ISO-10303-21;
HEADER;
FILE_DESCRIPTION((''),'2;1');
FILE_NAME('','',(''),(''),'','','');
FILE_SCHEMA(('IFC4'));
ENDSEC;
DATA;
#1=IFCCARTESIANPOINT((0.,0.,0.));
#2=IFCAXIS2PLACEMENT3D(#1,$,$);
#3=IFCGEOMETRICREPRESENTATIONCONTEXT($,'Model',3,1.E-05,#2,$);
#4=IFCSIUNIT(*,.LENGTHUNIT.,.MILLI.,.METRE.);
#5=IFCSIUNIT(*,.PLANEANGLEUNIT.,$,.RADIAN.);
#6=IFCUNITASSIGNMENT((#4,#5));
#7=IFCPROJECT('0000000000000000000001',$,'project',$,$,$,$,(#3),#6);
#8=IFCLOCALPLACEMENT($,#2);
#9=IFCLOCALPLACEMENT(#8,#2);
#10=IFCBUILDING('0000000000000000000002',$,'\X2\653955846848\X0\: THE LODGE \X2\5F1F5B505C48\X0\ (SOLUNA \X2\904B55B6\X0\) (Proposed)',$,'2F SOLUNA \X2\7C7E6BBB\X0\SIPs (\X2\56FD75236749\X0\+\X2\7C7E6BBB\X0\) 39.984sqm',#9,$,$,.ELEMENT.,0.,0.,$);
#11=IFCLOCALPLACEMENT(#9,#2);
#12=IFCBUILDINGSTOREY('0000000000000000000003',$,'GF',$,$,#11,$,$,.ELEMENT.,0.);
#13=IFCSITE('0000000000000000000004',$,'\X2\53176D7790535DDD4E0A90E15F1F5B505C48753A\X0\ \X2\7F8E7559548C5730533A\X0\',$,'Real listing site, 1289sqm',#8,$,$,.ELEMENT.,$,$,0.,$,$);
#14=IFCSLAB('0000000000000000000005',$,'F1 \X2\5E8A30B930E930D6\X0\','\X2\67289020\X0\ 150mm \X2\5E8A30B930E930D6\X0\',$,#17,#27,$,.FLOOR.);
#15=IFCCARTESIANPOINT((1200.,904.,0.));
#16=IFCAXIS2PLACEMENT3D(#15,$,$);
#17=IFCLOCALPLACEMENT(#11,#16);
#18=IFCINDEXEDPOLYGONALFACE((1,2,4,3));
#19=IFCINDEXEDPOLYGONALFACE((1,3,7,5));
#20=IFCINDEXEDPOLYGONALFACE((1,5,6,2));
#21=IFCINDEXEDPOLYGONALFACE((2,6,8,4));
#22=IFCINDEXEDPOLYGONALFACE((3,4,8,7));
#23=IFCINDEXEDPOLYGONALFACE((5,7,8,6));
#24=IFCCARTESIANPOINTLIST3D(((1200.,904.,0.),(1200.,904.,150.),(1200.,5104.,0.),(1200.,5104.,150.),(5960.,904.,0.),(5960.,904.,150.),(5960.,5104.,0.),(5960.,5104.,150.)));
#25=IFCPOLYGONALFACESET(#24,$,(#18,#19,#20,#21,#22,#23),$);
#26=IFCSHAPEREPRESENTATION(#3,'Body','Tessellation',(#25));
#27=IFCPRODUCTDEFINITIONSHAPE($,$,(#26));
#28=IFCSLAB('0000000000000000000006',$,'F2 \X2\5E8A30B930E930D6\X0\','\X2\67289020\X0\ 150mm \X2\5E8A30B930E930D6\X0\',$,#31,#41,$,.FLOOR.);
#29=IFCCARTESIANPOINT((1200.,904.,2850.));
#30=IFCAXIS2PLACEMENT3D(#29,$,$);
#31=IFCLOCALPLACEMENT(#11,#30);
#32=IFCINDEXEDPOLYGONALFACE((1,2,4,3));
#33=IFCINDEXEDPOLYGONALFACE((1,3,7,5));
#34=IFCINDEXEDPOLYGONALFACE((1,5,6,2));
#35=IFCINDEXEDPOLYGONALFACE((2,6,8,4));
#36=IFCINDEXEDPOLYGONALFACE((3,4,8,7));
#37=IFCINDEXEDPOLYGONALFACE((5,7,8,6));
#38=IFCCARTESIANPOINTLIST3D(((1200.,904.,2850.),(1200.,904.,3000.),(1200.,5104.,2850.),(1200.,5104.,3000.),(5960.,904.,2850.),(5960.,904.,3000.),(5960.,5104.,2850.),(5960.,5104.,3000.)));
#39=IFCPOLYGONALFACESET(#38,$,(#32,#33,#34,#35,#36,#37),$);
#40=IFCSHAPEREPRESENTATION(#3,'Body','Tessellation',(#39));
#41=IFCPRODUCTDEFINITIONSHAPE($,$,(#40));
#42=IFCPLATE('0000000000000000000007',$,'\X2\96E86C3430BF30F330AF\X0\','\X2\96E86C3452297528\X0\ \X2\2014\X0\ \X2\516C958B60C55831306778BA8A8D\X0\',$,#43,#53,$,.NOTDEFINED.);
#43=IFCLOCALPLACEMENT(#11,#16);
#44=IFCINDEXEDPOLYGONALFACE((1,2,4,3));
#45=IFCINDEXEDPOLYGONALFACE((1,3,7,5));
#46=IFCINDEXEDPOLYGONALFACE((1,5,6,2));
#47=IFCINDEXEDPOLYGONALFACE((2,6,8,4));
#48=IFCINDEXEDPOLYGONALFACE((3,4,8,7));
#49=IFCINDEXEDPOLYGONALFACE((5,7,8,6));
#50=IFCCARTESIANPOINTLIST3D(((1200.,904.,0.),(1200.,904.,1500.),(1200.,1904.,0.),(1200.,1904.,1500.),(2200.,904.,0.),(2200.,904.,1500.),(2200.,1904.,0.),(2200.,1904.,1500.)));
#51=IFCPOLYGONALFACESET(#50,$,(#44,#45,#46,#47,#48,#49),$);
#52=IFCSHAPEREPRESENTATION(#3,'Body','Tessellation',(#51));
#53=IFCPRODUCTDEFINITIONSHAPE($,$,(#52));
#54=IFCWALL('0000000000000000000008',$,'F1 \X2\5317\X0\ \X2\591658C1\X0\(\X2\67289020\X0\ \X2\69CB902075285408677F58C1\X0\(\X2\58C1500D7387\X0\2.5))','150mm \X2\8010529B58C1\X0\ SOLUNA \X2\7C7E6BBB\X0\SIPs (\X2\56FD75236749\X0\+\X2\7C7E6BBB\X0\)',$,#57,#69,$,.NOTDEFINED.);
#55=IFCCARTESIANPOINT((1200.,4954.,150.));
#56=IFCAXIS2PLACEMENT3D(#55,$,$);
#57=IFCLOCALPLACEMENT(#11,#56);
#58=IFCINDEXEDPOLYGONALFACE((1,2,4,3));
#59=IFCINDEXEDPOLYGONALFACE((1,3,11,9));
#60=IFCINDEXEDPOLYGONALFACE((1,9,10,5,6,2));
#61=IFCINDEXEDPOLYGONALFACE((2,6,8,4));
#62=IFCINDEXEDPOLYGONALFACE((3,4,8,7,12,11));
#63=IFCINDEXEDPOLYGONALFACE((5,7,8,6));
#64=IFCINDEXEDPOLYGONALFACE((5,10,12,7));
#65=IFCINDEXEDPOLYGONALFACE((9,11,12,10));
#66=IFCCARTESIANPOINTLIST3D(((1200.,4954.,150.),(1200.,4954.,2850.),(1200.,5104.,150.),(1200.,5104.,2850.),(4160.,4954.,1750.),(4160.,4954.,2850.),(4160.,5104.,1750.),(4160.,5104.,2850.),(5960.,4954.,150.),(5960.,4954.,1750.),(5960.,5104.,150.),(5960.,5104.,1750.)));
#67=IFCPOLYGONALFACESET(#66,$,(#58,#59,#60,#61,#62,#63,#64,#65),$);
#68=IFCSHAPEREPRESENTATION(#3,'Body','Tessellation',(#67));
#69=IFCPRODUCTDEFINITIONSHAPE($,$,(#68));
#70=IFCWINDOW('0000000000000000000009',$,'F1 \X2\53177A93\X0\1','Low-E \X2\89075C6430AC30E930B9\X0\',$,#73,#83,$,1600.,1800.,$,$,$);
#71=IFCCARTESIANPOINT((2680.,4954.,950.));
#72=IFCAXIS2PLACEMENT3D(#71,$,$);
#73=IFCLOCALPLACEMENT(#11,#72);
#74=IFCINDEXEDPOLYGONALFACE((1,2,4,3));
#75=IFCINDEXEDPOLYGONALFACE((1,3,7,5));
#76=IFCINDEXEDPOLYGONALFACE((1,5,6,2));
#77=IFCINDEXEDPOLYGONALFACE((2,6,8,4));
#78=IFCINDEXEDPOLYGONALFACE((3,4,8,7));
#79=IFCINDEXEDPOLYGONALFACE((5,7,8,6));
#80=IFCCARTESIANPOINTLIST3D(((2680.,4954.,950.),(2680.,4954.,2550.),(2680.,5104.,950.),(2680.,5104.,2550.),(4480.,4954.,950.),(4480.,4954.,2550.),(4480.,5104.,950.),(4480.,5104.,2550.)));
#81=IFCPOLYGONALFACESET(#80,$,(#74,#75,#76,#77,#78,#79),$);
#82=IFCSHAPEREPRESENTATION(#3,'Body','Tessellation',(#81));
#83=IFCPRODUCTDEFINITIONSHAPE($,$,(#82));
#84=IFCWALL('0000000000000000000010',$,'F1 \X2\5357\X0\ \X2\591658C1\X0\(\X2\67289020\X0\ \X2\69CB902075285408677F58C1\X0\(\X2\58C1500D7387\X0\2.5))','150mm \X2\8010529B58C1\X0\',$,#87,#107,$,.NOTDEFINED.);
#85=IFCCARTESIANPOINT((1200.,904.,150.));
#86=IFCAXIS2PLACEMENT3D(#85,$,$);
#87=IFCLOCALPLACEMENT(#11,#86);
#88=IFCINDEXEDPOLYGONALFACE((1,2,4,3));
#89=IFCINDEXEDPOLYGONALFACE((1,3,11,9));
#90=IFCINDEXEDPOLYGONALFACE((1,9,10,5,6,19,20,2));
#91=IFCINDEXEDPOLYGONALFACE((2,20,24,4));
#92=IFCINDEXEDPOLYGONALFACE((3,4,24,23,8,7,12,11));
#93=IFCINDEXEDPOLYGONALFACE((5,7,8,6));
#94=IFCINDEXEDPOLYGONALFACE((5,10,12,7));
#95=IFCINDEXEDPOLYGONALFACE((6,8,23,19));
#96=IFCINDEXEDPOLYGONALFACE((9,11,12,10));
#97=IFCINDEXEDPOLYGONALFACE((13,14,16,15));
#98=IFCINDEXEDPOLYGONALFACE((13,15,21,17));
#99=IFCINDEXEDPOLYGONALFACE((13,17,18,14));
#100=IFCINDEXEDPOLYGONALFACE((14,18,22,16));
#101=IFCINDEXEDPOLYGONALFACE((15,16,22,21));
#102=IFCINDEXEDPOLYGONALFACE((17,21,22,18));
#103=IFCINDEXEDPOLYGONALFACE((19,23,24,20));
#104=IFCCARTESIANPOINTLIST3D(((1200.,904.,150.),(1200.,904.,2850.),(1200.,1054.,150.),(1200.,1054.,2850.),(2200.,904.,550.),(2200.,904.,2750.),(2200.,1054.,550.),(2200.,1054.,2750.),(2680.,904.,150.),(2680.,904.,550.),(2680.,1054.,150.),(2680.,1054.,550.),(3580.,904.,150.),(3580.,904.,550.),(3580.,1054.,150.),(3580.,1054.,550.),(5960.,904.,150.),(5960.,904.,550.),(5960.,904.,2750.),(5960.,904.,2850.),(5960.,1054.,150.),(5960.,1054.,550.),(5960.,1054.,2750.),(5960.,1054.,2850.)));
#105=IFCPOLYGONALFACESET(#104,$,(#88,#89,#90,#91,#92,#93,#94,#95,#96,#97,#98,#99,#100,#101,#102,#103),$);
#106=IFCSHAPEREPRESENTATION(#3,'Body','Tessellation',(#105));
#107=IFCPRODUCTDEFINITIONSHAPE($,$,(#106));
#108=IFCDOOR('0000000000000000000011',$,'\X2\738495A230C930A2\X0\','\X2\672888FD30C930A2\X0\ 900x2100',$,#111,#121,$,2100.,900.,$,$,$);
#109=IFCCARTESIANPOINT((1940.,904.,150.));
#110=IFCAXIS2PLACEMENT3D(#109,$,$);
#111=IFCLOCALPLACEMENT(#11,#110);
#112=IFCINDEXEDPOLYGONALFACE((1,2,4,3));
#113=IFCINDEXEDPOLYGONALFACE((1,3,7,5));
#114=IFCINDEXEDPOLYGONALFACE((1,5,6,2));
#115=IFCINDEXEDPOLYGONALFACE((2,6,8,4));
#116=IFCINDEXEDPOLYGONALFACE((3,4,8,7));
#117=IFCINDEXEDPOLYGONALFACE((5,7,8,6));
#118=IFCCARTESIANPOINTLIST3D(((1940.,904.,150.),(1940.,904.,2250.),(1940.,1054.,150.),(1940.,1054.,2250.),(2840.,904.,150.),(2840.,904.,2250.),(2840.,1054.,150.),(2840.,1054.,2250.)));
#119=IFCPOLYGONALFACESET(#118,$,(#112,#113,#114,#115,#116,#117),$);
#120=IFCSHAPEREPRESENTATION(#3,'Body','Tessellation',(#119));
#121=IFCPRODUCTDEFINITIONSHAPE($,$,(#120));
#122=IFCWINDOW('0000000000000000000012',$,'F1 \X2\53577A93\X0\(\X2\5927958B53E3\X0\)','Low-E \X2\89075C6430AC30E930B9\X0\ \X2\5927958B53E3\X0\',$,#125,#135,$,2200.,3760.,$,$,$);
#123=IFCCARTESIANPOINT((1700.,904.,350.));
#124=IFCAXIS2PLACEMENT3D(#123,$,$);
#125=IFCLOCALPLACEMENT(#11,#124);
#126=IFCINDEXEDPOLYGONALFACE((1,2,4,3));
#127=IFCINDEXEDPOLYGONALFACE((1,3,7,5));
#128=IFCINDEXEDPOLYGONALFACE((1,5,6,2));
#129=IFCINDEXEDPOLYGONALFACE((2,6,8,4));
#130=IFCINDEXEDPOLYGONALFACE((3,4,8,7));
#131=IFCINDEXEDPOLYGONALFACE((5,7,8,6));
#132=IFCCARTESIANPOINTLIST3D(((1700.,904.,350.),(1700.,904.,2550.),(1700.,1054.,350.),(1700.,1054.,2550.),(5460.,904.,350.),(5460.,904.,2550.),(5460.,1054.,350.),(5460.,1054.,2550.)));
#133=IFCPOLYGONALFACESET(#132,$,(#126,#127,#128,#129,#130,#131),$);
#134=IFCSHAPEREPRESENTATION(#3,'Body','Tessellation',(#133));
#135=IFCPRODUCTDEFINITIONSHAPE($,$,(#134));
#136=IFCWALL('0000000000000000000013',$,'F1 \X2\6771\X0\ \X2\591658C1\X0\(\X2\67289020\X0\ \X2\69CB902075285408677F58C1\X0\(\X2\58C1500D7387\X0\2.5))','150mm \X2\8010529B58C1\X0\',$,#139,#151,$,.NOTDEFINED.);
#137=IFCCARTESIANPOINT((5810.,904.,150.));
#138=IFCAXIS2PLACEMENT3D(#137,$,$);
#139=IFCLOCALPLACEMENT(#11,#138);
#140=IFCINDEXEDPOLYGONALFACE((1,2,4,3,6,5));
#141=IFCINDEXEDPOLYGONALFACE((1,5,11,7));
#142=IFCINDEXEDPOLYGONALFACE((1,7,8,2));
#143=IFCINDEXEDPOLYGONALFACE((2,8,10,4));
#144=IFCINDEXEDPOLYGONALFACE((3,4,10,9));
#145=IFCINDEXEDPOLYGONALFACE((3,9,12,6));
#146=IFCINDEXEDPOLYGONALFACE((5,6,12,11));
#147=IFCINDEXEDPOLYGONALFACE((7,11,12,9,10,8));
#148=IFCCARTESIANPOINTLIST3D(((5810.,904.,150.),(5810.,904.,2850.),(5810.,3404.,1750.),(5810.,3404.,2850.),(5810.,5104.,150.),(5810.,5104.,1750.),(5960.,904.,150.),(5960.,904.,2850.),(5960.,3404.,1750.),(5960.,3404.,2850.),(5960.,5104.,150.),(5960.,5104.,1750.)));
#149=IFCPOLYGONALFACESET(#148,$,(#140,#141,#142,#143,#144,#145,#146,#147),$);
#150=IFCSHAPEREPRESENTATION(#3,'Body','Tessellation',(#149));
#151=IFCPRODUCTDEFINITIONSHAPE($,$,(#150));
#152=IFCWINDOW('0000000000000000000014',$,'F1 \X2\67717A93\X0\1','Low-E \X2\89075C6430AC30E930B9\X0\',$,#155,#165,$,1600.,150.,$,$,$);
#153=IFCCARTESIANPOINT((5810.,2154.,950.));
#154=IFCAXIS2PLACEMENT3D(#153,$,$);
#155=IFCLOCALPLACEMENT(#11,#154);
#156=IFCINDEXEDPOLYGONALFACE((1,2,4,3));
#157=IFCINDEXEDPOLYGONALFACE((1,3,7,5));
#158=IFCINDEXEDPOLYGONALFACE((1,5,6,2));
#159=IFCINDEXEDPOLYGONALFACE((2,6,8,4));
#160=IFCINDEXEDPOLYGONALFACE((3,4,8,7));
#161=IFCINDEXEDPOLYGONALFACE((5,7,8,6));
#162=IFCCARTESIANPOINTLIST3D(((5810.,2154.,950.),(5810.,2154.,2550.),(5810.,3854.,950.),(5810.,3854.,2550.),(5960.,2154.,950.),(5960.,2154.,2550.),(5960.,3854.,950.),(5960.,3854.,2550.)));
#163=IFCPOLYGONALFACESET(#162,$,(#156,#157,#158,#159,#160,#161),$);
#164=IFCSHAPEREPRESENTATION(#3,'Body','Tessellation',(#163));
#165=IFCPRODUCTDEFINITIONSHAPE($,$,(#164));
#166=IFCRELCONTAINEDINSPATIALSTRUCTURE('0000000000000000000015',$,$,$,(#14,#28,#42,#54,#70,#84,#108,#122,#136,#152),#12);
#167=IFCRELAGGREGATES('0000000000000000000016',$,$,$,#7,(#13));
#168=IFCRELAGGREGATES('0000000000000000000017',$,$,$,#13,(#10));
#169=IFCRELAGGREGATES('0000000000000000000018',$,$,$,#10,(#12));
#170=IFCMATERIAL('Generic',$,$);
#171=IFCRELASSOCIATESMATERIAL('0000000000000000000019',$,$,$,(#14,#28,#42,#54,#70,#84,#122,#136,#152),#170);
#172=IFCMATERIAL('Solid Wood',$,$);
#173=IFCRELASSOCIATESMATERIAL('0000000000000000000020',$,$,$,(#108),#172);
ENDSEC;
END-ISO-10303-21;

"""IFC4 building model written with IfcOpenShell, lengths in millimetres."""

from ifc_helpers import new_model, si_unit, frame, frame_2d, origin, place, context, project, spatial, rectangle, extrude, material, element, fill, save


model = new_model("IFC4")

# Units and contexts
model_context = context("Model", 3, precision=1e-05, world=origin())
ifc_project = project(units=[si_unit("LENGTHUNIT", "METRE", prefix="MILLI"), si_unit("PLANEANGLEUNIT", "RADIAN")], contexts=[model_context])

# Site, building, storey
site_placement = place(None, origin())
site = spatial("IfcSite", under=ifc_project, at=site_placement, Name="北海道川上郡弟子屈町 美留和地区", ObjectType="Real listing site, 1289sqm", CompositionType="ELEMENT", RefElevation=0.0)
building_placement = place(site_placement, origin())
building = spatial("IfcBuilding", under=site, at=building_placement, Name="改善案: THE LODGE 弟子屈 (SOLUNA 運営) (Proposed)", ObjectType="2F SOLUNA 籾殻SIPs (国産杉+籾殻) 39.984sqm", CompositionType="ELEMENT", ElevationOfRefHeight=0.0, ElevationOfTerrain=0.0)
storey_placement = place(building_placement, origin())
storey = spatial("IfcBuildingStorey", under=building, at=storey_placement, Name="GF", CompositionType="ELEMENT", Elevation=0.0)

# Slabs
ifc_material_1 = material(Name="Generic")
slab_1_placement = place(storey_placement, frame((1200.0, 904.0, 0.0)))
element("IfcSlab", 1, at=slab_1_placement, inside=storey, material=ifc_material_1, Name="F1 床スラブ", Description="木造 150mm 床スラブ", PredefinedType="FLOOR", context=model_context, shape_type="SweptSolid", body=[
    extrude(rectangle(XDim=4760.0, YDim=4200.0, at=frame_2d((2380.0, 2100.0))), frame((1200.0, 904.0, 0.0)), (0.0, 0.0, 1.0), 150.0),
])
slab_2_placement = place(storey_placement, frame((1200.0, 904.0, 2850.0)))
element("IfcSlab", 2, at=slab_2_placement, inside=storey, material=ifc_material_1, Name="F2 床スラブ", Description="木造 150mm 床スラブ", PredefinedType="FLOOR", context=model_context, shape_type="SweptSolid", body=[
    extrude(rectangle(XDim=4760.0, YDim=4200.0, at=frame_2d((2380.0, 2100.0))), frame((1200.0, 904.0, 2850.0)), (0.0, 0.0, 1.0), 150.0),
])

# Plate
plate_placement = place(storey_placement, frame((1200.0, 904.0, 0.0)))
element("IfcPlate", 3, at=plate_placement, inside=storey, material=ifc_material_1, Name="雨水タンク", Description="雨水利用 — 公開情報で確認", PredefinedType="NOTDEFINED", context=model_context, shape_type="SweptSolid", body=[
    extrude(rectangle(XDim=1000.0, YDim=1000.0, at=frame_2d((500.0, 500.0))), frame((1200.0, 904.0, 0.0)), (0.0, 0.0, 1.0), 1500.0),
])

# Wall, opening, window
wall_1_placement = place(storey_placement, frame((1200.0, 4954.0, 150.0)))
wall_1 = element("IfcWall", 4, at=wall_1_placement, inside=storey, material=ifc_material_1, Name="F1 北 外壁(木造 構造用合板壁(壁倍率2.5))", Description="150mm 耐力壁 SOLUNA 籾殻SIPs (国産杉+籾殻)", PredefinedType="NOTDEFINED", context=model_context, shape_type="SweptSolid", body=[
    extrude(rectangle(XDim=4760.0, YDim=150.0, at=frame_2d((2380.0, 75.0))), frame((1200.0, 4954.0, 150.0)), (0.0, 0.0, 1.0), 2700.0),
])
opening_1_placement = place(storey_placement, frame((2680.0, 4954.0, 950.0)))
opening_1 = element("IfcOpeningElement", 5, at=opening_1_placement, cuts=wall_1, PredefinedType="NOTDEFINED", context=model_context, shape_type="SweptSolid", body=[
    extrude(rectangle(XDim=1800.0, YDim=150.0, at=frame_2d((900.0, 75.0))), frame((2680.0, 4954.0, 950.0)), (0.0, 0.0, 1.0), 1600.0),
])
window_1_placement = place(storey_placement, frame((2680.0, 4954.0, 950.0)))
window_1 = element("IfcWindow", 6, at=window_1_placement, inside=storey, material=ifc_material_1, Name="F1 北窓1", Description="Low-E 複層ガラス", OverallHeight=1600.0, OverallWidth=1800.0, context=model_context, shape_type="SweptSolid", body=[
    extrude(rectangle(XDim=1800.0, YDim=150.0, at=frame_2d((900.0, 75.0))), frame((2680.0, 4954.0, 950.0)), (0.0, 0.0, 1.0), 1600.0),
])
fill(opening_1, window_1)

# Wall, openings, door, window
wall_2_placement = place(storey_placement, frame((1200.0, 904.0, 150.0)))
wall_2 = element("IfcWall", 7, at=wall_2_placement, inside=storey, material=ifc_material_1, Name="F1 南 外壁(木造 構造用合板壁(壁倍率2.5))", Description="150mm 耐力壁", PredefinedType="NOTDEFINED", context=model_context, shape_type="SweptSolid", body=[
    extrude(rectangle(XDim=4760.0, YDim=150.0, at=frame_2d((2380.0, 75.0))), frame((1200.0, 904.0, 150.0)), (0.0, 0.0, 1.0), 2700.0),
])
opening_2_placement = place(storey_placement, frame((1940.0, 904.0, 150.0)))
opening_2 = element("IfcOpeningElement", 8, at=opening_2_placement, cuts=wall_2, PredefinedType="NOTDEFINED", context=model_context, shape_type="SweptSolid", body=[
    extrude(rectangle(XDim=900.0, YDim=150.0, at=frame_2d((450.0, 75.0))), frame((1940.0, 904.0, 150.0)), (0.0, 0.0, 1.0), 2100.0),
])
opening_3_placement = place(storey_placement, frame((1700.0, 904.0, 350.0)))
opening_3 = element("IfcOpeningElement", 9, at=opening_3_placement, cuts=wall_2, PredefinedType="NOTDEFINED", context=model_context, shape_type="SweptSolid", body=[
    extrude(rectangle(XDim=3760.0, YDim=150.0, at=frame_2d((1880.0, 75.0))), frame((1700.0, 904.0, 350.0)), (0.0, 0.0, 1.0), 2200.0),
])
ifc_material_2 = material(Name="Solid Wood")
door_placement = place(storey_placement, frame((1940.0, 904.0, 150.0)))
door = element("IfcDoor", 10, at=door_placement, inside=storey, material=ifc_material_2, Name="玄関ドア", Description="木製ドア 900x2100", OverallHeight=2100.0, OverallWidth=900.0, context=model_context, shape_type="SweptSolid", body=[
    extrude(rectangle(XDim=900.0, YDim=150.0, at=frame_2d((450.0, 75.0))), frame((1940.0, 904.0, 150.0)), (0.0, 0.0, 1.0), 2100.0),
])
fill(opening_2, door)
window_2_placement = place(storey_placement, frame((1700.0, 904.0, 350.0)))
window_2 = element("IfcWindow", 11, at=window_2_placement, inside=storey, material=ifc_material_1, Name="F1 南窓(大開口)", Description="Low-E 複層ガラス 大開口", OverallHeight=2200.0, OverallWidth=3760.0, context=model_context, shape_type="SweptSolid", body=[
    extrude(rectangle(XDim=3760.0, YDim=150.0, at=frame_2d((1880.0, 75.0))), frame((1700.0, 904.0, 350.0)), (0.0, 0.0, 1.0), 2200.0),
])
fill(opening_3, window_2)

# Wall, opening, window
wall_3_placement = place(storey_placement, frame((5810.0, 904.0, 150.0)))
wall_3 = element("IfcWall", 12, at=wall_3_placement, inside=storey, material=ifc_material_1, Name="F1 東 外壁(木造 構造用合板壁(壁倍率2.5))", Description="150mm 耐力壁", PredefinedType="NOTDEFINED", context=model_context, shape_type="SweptSolid", body=[
    extrude(rectangle(XDim=150.0, YDim=4200.0, at=frame_2d((75.0, 2100.0))), frame((5810.0, 904.0, 150.0)), (0.0, 0.0, 1.0), 2700.0),
])
opening_4_placement = place(storey_placement, frame((5810.0, 2154.0, 950.0)))
opening_4 = element("IfcOpeningElement", 13, at=opening_4_placement, cuts=wall_3, PredefinedType="NOTDEFINED", context=model_context, shape_type="SweptSolid", body=[
    extrude(rectangle(XDim=150.0, YDim=1700.0, at=frame_2d((75.0, 850.0))), frame((5810.0, 2154.0, 950.0)), (0.0, 0.0, 1.0), 1600.0),
])
window_3_placement = place(storey_placement, frame((5810.0, 2154.0, 950.0)))
window_3 = element("IfcWindow", 14, at=window_3_placement, inside=storey, material=ifc_material_1, Name="F1 東窓1", Description="Low-E 複層ガラス", OverallHeight=1600.0, OverallWidth=150.0, context=model_context, shape_type="SweptSolid", body=[
    extrude(rectangle(XDim=150.0, YDim=1700.0, at=frame_2d((75.0, 850.0))), frame((5810.0, 2154.0, 950.0)), (0.0, 0.0, 1.0), 1600.0),
])
fill(opening_4, window_3)

save(model, "model.ifc")
